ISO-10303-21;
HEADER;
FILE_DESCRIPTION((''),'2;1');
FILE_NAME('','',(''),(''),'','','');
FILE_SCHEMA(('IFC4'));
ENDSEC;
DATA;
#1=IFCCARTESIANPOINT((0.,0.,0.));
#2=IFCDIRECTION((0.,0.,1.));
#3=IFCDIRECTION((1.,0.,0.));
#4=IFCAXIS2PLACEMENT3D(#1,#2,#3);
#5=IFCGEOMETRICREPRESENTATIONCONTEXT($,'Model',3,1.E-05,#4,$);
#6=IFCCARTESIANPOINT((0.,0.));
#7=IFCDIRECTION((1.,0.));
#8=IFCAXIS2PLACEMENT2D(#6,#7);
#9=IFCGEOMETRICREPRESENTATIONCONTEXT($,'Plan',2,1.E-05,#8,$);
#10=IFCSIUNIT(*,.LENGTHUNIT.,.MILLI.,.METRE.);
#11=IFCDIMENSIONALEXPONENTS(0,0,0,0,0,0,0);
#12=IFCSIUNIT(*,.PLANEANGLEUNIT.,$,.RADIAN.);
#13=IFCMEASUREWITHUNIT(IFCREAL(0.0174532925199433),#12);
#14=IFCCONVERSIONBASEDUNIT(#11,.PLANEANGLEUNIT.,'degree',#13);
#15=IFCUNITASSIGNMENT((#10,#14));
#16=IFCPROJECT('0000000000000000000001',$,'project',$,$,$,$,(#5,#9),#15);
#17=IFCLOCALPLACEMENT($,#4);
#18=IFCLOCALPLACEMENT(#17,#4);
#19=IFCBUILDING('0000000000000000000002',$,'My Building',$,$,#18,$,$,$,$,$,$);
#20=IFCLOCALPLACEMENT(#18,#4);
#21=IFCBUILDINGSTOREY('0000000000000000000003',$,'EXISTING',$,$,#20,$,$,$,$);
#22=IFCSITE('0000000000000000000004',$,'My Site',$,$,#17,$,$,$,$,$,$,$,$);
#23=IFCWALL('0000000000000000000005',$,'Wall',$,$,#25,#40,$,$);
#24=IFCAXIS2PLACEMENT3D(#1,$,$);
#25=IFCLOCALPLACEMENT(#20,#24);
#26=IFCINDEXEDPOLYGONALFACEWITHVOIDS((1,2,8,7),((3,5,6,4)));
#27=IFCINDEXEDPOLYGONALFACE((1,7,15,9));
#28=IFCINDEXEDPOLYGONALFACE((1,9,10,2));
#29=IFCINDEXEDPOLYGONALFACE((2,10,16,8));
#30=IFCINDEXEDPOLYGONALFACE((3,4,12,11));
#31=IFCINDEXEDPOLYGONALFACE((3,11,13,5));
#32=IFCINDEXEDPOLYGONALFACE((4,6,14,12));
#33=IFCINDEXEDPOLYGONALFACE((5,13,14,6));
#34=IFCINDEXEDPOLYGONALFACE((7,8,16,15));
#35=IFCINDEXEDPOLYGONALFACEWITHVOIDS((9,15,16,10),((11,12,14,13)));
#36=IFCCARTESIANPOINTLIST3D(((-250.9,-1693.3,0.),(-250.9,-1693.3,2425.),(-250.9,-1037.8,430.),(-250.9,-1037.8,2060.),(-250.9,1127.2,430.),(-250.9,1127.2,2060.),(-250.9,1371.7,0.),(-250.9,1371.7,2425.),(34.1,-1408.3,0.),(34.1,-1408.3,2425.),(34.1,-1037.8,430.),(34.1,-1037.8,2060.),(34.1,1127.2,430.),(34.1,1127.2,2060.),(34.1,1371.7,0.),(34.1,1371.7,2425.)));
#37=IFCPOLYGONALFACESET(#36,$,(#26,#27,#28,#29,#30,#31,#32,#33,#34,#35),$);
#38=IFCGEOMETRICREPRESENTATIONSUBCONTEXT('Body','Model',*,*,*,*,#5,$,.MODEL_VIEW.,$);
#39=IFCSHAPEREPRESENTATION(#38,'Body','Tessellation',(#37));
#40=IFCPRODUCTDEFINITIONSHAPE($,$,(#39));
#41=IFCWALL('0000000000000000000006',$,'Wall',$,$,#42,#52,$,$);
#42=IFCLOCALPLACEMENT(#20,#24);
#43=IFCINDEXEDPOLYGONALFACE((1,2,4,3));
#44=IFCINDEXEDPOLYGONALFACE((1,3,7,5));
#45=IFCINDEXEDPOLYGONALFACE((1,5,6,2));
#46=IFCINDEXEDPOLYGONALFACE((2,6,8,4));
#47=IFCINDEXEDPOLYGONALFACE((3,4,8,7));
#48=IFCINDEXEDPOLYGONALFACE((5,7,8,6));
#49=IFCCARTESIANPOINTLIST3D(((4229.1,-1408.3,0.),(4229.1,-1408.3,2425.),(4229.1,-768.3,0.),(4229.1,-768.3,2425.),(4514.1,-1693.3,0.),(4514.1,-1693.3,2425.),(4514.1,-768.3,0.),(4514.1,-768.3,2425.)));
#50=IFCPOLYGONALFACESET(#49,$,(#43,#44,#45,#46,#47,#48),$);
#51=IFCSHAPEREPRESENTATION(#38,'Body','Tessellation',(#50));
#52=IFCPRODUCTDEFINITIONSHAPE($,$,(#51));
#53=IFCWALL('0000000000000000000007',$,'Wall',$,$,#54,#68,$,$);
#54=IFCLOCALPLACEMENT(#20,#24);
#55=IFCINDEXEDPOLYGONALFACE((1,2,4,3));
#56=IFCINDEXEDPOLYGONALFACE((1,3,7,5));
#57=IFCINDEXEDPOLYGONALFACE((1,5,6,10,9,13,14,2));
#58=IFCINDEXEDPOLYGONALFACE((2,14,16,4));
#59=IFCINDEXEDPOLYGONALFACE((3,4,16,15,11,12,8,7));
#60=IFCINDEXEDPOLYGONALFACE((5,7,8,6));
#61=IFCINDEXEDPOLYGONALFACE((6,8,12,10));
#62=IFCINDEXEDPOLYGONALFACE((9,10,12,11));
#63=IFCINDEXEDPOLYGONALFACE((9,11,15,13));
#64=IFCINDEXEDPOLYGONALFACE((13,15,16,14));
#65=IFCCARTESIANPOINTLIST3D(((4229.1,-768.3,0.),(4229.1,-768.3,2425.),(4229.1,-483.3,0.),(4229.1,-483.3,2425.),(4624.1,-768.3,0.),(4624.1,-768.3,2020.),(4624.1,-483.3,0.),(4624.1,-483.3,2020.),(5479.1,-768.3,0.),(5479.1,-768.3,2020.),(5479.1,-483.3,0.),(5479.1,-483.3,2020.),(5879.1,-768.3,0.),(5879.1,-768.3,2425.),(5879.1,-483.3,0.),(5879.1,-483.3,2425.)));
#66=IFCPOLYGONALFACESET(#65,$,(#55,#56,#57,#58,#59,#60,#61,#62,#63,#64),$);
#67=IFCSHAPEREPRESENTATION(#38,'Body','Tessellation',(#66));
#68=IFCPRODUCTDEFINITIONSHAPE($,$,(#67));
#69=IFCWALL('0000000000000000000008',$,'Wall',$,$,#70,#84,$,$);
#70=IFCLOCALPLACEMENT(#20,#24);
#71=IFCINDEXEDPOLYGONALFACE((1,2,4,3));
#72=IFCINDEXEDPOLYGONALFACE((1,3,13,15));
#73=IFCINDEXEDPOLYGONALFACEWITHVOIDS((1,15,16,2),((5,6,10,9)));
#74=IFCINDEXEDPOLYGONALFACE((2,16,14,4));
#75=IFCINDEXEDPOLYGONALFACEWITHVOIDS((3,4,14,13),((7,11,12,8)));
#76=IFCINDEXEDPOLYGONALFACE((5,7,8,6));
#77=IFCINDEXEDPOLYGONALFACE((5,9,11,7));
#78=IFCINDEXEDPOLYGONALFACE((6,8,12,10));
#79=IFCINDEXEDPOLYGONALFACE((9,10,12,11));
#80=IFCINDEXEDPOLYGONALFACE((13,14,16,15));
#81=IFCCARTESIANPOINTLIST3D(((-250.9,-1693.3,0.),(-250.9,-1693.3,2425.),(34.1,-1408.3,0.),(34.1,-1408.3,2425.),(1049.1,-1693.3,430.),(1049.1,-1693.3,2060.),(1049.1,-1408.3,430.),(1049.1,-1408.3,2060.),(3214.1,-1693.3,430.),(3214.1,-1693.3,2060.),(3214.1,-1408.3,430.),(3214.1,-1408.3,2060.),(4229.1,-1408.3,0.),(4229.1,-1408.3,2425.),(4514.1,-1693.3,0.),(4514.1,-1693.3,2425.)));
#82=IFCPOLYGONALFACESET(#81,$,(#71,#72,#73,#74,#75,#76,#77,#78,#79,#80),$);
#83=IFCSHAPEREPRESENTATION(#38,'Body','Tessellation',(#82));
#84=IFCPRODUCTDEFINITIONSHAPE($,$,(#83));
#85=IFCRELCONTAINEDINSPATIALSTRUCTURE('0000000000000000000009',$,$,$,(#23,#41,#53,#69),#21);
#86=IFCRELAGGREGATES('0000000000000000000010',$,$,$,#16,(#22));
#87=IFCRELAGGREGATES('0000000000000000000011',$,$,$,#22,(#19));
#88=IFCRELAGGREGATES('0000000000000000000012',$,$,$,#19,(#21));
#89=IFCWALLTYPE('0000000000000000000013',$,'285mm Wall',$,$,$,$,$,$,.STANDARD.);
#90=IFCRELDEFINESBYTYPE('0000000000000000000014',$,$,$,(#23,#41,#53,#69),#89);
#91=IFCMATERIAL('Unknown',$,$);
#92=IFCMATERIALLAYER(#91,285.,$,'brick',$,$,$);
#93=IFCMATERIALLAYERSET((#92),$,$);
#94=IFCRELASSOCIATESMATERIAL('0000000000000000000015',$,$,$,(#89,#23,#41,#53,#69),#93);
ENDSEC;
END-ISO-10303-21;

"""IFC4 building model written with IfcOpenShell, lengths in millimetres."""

from ifc_helpers import new_model, entity, si_unit, converted_unit, frame, origin_with_axes, origin_2d_with_axis, place, context, subcontext, project, spatial, line, indexed_curve, outline, extrude, clip, halfspace, source, transform, mapped, material, layer, layer_set, layer_usage, type_object, element, save


model = new_model("IFC4")

# Units and contexts
model_context = context("Model", 3, precision=1e-05, world=origin_with_axes())
plan_context = context("Plan", 2, precision=1e-05, world=origin_2d_with_axis())
body_context = subcontext(model_context, "Body", "Model", "MODEL_VIEW")
ifc_project = project(units=[si_unit("LENGTHUNIT", "METRE", prefix="MILLI"), converted_unit("PLANEANGLEUNIT", "degree", entity("IfcReal", 0.0174532925199433), si_unit("PLANEANGLEUNIT", "RADIAN"), dimensions=[0, 0, 0, 0, 0, 0, 0])], contexts=[model_context, plan_context])

# Site, building, storey
site_placement = place(None, origin_with_axes())
site = spatial("IfcSite", under=ifc_project, at=site_placement, Name="My Site")
building_placement = place(site_placement, origin_with_axes())
building = spatial("IfcBuilding", under=site, at=building_placement, Name="My Building")
storey_placement = place(building_placement, origin_with_axes())
storey = spatial("IfcBuildingStorey", under=building, at=storey_placement, Name="EXISTING")

# Shared definitions
ifc_material = material(Name="Unknown")

# Shared definitions
ifc_layer_1 = layer(ifc_material, 285.0, Name="brick")
ifc_layer_set_1 = layer_set([ifc_layer_1])
wall_type_1 = type_object("IfcWallType", Name="285mm Wall", PredefinedType="STANDARD", material=ifc_layer_set_1)

# Wall, opening
ifc_layer_usage_1 = layer_usage(ifc_layer_set_1, "AXIS2", "POSITIVE", 0.0)
wall_1_placement = place(storey_placement, frame((34.1, -1693.3, 0.0), z_axis=(0.0, 0.0, 1.0), x_axis=(0.0, 1.0, 0.0)))
wall_1 = element("IfcWall", 1, at=wall_1_placement, inside=storey, type_object=wall_type_1, material=ifc_layer_usage_1, Name="Wall", context=body_context, shape_type="Clipping", body=[
    clip(extrude(outline(indexed_curve([(0.0, 0.0), (0.0, 285.0), (3065.0, 285.0), (3065.0, 0.0), (0.0, 0.0)], self_intersect=False)), origin_with_axes(), (0.0, 0.0, 1.0), 2425.0), halfspace(frame((285.0, 0.0, 0.0), z_axis=(-0.707107, -0.707107, 0.0), x_axis=(-0.707107, 0.707107, 0.0)), False)),
])
shared_shape_1 = source(origin_with_axes(), body_context, "Body", "SweptSolid", [
    extrude(outline(indexed_curve([(0.0, 0.0), (2165.0, 0.0), (2165.0, 1630.0), (0.0, 1630.0)], segments=[line(1, 2, 3, 4, 1)])), frame((0.0, -600.0, 0.0), z_axis=(0.0, -1.0, 0.0), x_axis=(1.0, 0.0, 0.0)), (0.0, 0.0, -1.0), 1200.0),
])
opening_1_placement = place(wall_1_placement, frame((655.5, 148.9, 430.0), z_axis=(0.0, 0.0, 1.0), x_axis=(1.0, 0.0, 0.0)))
element("IfcOpeningElement", 2, at=opening_1_placement, cuts=wall_1, PredefinedType="OPENING", context=body_context, shape_type="MappedRepresentation", body=[
    mapped(shared_shape_1, transform((0.0, 0.0, 0.0), x_axis=(1.0, 0.0, 0.0), y_axis=(0.0, 1.0, 0.0), z_axis=(0.0, 0.0, 1.0), scale=1.0)),
])

# Wall
ifc_layer_usage_2 = layer_usage(ifc_layer_set_1, "AXIS2", "POSITIVE", 0.0)
wall_2_placement = place(storey_placement, frame((4514.1, -1693.3, 0.0), z_axis=(0.0, 0.0, 1.0), x_axis=(0.0, 1.0, 0.0)))
element("IfcWall", 3, at=wall_2_placement, inside=storey, type_object=wall_type_1, material=ifc_layer_usage_2, Name="Wall", context=body_context, shape_type="Clipping", body=[
    clip(extrude(outline(indexed_curve([(0.0, 0.0), (0.0, 285.0), (925.0, 285.0), (925.0, 0.0), (0.0, 0.0)], self_intersect=False)), origin_with_axes(), (0.0, 0.0, 1.0), 2425.0), halfspace(frame((0.0, 0.0, 0.0), z_axis=(-0.707107, 0.707107, 0.0), x_axis=(0.707107, 0.707107, 0.0)), False)),
])

# Walls, openings
ifc_layer_usage_3 = layer_usage(ifc_layer_set_1, "AXIS2", "POSITIVE", 0.0)
wall_3_placement = place(storey_placement, frame((4229.1, -768.3, 0.0), z_axis=(0.0, 0.0, 1.0), x_axis=(1.0, 0.0, 0.0)))
wall_3 = element("IfcWall", 4, at=wall_3_placement, inside=storey, type_object=wall_type_1, material=ifc_layer_usage_3, Name="Wall", context=body_context, shape_type="SweptSolid", body=[
    extrude(outline(indexed_curve([(0.0, 0.0), (0.0, 285.0), (1650.0, 285.0), (1650.0, 0.0), (0.0, 0.0)], self_intersect=False)), origin_with_axes(), (0.0, 0.0, 1.0), 2425.0),
])
shared_shape_2 = source(origin_with_axes(), body_context, "Body", "SweptSolid", [
    extrude(outline(indexed_curve([(0.0, 0.0), (855.0, 0.0), (855.0, 2020.0), (0.0, 2020.0)], segments=[line(1, 2, 3, 4, 1)])), frame((0.0, -600.0, 0.0), z_axis=(0.0, -1.0, 0.0), x_axis=(1.0, 0.0, 0.0)), (0.0, 0.0, -1.0), 1200.0),
])
opening_2_placement = place(wall_3_placement, frame((1250.0, 170.3, 0.0), z_axis=(0.0, 0.0, 1.0), x_axis=(-1.0, 0.0, 0.0)))
element("IfcOpeningElement", 5, at=opening_2_placement, cuts=wall_3, PredefinedType="OPENING", context=body_context, shape_type="MappedRepresentation", body=[
    mapped(shared_shape_2, transform((0.0, 0.0, 0.0), x_axis=(1.0, 0.0, 0.0), y_axis=(0.0, 1.0, 0.0), z_axis=(0.0, 0.0, 1.0), scale=1.0)),
])
ifc_layer_usage_4 = layer_usage(ifc_layer_set_1, "AXIS2", "POSITIVE", 0.0)
wall_4_placement = place(storey_placement, frame((-250.9, -1693.3, 0.0), z_axis=(0.0, 0.0, 1.0), x_axis=(1.0, 0.0, 0.0)))
wall_4 = element("IfcWall", 6, at=wall_4_placement, inside=storey, type_object=wall_type_1, material=ifc_layer_usage_4, Name="Wall", context=body_context, shape_type="Clipping", body=[
    clip(clip(extrude(outline(indexed_curve([(0.0, 0.0), (0.0, 285.0), (4765.0, 285.0), (4765.0, 0.0), (0.0, 0.0)], self_intersect=False)), origin_with_axes(), (0.0, 0.0, 1.0), 2425.0), halfspace(frame((0.0, 0.0, 0.0), z_axis=(-0.707107, 0.707107, 0.0), x_axis=(0.707107, 0.707107, 0.0)), False)), halfspace(frame((4765.0, 0.0, 0.0), z_axis=(0.707107, 0.707107, 0.0), x_axis=(0.707107, -0.707107, 0.0)), False)),
])
opening_3_placement = place(wall_4_placement, frame((3465.0, 136.1, 430.0), z_axis=(0.0, 0.0, 1.0), x_axis=(-1.0, 0.0, 0.0)))
element("IfcOpeningElement", 7, at=opening_3_placement, cuts=wall_4, PredefinedType="OPENING", context=body_context, shape_type="MappedRepresentation", body=[
    mapped(shared_shape_1, transform((0.0, 0.0, 0.0), x_axis=(1.0, 0.0, 0.0), y_axis=(0.0, 1.0, 0.0), z_axis=(0.0, 0.0, 1.0), scale=1.0)),
])

save(model, "model.ifc")
